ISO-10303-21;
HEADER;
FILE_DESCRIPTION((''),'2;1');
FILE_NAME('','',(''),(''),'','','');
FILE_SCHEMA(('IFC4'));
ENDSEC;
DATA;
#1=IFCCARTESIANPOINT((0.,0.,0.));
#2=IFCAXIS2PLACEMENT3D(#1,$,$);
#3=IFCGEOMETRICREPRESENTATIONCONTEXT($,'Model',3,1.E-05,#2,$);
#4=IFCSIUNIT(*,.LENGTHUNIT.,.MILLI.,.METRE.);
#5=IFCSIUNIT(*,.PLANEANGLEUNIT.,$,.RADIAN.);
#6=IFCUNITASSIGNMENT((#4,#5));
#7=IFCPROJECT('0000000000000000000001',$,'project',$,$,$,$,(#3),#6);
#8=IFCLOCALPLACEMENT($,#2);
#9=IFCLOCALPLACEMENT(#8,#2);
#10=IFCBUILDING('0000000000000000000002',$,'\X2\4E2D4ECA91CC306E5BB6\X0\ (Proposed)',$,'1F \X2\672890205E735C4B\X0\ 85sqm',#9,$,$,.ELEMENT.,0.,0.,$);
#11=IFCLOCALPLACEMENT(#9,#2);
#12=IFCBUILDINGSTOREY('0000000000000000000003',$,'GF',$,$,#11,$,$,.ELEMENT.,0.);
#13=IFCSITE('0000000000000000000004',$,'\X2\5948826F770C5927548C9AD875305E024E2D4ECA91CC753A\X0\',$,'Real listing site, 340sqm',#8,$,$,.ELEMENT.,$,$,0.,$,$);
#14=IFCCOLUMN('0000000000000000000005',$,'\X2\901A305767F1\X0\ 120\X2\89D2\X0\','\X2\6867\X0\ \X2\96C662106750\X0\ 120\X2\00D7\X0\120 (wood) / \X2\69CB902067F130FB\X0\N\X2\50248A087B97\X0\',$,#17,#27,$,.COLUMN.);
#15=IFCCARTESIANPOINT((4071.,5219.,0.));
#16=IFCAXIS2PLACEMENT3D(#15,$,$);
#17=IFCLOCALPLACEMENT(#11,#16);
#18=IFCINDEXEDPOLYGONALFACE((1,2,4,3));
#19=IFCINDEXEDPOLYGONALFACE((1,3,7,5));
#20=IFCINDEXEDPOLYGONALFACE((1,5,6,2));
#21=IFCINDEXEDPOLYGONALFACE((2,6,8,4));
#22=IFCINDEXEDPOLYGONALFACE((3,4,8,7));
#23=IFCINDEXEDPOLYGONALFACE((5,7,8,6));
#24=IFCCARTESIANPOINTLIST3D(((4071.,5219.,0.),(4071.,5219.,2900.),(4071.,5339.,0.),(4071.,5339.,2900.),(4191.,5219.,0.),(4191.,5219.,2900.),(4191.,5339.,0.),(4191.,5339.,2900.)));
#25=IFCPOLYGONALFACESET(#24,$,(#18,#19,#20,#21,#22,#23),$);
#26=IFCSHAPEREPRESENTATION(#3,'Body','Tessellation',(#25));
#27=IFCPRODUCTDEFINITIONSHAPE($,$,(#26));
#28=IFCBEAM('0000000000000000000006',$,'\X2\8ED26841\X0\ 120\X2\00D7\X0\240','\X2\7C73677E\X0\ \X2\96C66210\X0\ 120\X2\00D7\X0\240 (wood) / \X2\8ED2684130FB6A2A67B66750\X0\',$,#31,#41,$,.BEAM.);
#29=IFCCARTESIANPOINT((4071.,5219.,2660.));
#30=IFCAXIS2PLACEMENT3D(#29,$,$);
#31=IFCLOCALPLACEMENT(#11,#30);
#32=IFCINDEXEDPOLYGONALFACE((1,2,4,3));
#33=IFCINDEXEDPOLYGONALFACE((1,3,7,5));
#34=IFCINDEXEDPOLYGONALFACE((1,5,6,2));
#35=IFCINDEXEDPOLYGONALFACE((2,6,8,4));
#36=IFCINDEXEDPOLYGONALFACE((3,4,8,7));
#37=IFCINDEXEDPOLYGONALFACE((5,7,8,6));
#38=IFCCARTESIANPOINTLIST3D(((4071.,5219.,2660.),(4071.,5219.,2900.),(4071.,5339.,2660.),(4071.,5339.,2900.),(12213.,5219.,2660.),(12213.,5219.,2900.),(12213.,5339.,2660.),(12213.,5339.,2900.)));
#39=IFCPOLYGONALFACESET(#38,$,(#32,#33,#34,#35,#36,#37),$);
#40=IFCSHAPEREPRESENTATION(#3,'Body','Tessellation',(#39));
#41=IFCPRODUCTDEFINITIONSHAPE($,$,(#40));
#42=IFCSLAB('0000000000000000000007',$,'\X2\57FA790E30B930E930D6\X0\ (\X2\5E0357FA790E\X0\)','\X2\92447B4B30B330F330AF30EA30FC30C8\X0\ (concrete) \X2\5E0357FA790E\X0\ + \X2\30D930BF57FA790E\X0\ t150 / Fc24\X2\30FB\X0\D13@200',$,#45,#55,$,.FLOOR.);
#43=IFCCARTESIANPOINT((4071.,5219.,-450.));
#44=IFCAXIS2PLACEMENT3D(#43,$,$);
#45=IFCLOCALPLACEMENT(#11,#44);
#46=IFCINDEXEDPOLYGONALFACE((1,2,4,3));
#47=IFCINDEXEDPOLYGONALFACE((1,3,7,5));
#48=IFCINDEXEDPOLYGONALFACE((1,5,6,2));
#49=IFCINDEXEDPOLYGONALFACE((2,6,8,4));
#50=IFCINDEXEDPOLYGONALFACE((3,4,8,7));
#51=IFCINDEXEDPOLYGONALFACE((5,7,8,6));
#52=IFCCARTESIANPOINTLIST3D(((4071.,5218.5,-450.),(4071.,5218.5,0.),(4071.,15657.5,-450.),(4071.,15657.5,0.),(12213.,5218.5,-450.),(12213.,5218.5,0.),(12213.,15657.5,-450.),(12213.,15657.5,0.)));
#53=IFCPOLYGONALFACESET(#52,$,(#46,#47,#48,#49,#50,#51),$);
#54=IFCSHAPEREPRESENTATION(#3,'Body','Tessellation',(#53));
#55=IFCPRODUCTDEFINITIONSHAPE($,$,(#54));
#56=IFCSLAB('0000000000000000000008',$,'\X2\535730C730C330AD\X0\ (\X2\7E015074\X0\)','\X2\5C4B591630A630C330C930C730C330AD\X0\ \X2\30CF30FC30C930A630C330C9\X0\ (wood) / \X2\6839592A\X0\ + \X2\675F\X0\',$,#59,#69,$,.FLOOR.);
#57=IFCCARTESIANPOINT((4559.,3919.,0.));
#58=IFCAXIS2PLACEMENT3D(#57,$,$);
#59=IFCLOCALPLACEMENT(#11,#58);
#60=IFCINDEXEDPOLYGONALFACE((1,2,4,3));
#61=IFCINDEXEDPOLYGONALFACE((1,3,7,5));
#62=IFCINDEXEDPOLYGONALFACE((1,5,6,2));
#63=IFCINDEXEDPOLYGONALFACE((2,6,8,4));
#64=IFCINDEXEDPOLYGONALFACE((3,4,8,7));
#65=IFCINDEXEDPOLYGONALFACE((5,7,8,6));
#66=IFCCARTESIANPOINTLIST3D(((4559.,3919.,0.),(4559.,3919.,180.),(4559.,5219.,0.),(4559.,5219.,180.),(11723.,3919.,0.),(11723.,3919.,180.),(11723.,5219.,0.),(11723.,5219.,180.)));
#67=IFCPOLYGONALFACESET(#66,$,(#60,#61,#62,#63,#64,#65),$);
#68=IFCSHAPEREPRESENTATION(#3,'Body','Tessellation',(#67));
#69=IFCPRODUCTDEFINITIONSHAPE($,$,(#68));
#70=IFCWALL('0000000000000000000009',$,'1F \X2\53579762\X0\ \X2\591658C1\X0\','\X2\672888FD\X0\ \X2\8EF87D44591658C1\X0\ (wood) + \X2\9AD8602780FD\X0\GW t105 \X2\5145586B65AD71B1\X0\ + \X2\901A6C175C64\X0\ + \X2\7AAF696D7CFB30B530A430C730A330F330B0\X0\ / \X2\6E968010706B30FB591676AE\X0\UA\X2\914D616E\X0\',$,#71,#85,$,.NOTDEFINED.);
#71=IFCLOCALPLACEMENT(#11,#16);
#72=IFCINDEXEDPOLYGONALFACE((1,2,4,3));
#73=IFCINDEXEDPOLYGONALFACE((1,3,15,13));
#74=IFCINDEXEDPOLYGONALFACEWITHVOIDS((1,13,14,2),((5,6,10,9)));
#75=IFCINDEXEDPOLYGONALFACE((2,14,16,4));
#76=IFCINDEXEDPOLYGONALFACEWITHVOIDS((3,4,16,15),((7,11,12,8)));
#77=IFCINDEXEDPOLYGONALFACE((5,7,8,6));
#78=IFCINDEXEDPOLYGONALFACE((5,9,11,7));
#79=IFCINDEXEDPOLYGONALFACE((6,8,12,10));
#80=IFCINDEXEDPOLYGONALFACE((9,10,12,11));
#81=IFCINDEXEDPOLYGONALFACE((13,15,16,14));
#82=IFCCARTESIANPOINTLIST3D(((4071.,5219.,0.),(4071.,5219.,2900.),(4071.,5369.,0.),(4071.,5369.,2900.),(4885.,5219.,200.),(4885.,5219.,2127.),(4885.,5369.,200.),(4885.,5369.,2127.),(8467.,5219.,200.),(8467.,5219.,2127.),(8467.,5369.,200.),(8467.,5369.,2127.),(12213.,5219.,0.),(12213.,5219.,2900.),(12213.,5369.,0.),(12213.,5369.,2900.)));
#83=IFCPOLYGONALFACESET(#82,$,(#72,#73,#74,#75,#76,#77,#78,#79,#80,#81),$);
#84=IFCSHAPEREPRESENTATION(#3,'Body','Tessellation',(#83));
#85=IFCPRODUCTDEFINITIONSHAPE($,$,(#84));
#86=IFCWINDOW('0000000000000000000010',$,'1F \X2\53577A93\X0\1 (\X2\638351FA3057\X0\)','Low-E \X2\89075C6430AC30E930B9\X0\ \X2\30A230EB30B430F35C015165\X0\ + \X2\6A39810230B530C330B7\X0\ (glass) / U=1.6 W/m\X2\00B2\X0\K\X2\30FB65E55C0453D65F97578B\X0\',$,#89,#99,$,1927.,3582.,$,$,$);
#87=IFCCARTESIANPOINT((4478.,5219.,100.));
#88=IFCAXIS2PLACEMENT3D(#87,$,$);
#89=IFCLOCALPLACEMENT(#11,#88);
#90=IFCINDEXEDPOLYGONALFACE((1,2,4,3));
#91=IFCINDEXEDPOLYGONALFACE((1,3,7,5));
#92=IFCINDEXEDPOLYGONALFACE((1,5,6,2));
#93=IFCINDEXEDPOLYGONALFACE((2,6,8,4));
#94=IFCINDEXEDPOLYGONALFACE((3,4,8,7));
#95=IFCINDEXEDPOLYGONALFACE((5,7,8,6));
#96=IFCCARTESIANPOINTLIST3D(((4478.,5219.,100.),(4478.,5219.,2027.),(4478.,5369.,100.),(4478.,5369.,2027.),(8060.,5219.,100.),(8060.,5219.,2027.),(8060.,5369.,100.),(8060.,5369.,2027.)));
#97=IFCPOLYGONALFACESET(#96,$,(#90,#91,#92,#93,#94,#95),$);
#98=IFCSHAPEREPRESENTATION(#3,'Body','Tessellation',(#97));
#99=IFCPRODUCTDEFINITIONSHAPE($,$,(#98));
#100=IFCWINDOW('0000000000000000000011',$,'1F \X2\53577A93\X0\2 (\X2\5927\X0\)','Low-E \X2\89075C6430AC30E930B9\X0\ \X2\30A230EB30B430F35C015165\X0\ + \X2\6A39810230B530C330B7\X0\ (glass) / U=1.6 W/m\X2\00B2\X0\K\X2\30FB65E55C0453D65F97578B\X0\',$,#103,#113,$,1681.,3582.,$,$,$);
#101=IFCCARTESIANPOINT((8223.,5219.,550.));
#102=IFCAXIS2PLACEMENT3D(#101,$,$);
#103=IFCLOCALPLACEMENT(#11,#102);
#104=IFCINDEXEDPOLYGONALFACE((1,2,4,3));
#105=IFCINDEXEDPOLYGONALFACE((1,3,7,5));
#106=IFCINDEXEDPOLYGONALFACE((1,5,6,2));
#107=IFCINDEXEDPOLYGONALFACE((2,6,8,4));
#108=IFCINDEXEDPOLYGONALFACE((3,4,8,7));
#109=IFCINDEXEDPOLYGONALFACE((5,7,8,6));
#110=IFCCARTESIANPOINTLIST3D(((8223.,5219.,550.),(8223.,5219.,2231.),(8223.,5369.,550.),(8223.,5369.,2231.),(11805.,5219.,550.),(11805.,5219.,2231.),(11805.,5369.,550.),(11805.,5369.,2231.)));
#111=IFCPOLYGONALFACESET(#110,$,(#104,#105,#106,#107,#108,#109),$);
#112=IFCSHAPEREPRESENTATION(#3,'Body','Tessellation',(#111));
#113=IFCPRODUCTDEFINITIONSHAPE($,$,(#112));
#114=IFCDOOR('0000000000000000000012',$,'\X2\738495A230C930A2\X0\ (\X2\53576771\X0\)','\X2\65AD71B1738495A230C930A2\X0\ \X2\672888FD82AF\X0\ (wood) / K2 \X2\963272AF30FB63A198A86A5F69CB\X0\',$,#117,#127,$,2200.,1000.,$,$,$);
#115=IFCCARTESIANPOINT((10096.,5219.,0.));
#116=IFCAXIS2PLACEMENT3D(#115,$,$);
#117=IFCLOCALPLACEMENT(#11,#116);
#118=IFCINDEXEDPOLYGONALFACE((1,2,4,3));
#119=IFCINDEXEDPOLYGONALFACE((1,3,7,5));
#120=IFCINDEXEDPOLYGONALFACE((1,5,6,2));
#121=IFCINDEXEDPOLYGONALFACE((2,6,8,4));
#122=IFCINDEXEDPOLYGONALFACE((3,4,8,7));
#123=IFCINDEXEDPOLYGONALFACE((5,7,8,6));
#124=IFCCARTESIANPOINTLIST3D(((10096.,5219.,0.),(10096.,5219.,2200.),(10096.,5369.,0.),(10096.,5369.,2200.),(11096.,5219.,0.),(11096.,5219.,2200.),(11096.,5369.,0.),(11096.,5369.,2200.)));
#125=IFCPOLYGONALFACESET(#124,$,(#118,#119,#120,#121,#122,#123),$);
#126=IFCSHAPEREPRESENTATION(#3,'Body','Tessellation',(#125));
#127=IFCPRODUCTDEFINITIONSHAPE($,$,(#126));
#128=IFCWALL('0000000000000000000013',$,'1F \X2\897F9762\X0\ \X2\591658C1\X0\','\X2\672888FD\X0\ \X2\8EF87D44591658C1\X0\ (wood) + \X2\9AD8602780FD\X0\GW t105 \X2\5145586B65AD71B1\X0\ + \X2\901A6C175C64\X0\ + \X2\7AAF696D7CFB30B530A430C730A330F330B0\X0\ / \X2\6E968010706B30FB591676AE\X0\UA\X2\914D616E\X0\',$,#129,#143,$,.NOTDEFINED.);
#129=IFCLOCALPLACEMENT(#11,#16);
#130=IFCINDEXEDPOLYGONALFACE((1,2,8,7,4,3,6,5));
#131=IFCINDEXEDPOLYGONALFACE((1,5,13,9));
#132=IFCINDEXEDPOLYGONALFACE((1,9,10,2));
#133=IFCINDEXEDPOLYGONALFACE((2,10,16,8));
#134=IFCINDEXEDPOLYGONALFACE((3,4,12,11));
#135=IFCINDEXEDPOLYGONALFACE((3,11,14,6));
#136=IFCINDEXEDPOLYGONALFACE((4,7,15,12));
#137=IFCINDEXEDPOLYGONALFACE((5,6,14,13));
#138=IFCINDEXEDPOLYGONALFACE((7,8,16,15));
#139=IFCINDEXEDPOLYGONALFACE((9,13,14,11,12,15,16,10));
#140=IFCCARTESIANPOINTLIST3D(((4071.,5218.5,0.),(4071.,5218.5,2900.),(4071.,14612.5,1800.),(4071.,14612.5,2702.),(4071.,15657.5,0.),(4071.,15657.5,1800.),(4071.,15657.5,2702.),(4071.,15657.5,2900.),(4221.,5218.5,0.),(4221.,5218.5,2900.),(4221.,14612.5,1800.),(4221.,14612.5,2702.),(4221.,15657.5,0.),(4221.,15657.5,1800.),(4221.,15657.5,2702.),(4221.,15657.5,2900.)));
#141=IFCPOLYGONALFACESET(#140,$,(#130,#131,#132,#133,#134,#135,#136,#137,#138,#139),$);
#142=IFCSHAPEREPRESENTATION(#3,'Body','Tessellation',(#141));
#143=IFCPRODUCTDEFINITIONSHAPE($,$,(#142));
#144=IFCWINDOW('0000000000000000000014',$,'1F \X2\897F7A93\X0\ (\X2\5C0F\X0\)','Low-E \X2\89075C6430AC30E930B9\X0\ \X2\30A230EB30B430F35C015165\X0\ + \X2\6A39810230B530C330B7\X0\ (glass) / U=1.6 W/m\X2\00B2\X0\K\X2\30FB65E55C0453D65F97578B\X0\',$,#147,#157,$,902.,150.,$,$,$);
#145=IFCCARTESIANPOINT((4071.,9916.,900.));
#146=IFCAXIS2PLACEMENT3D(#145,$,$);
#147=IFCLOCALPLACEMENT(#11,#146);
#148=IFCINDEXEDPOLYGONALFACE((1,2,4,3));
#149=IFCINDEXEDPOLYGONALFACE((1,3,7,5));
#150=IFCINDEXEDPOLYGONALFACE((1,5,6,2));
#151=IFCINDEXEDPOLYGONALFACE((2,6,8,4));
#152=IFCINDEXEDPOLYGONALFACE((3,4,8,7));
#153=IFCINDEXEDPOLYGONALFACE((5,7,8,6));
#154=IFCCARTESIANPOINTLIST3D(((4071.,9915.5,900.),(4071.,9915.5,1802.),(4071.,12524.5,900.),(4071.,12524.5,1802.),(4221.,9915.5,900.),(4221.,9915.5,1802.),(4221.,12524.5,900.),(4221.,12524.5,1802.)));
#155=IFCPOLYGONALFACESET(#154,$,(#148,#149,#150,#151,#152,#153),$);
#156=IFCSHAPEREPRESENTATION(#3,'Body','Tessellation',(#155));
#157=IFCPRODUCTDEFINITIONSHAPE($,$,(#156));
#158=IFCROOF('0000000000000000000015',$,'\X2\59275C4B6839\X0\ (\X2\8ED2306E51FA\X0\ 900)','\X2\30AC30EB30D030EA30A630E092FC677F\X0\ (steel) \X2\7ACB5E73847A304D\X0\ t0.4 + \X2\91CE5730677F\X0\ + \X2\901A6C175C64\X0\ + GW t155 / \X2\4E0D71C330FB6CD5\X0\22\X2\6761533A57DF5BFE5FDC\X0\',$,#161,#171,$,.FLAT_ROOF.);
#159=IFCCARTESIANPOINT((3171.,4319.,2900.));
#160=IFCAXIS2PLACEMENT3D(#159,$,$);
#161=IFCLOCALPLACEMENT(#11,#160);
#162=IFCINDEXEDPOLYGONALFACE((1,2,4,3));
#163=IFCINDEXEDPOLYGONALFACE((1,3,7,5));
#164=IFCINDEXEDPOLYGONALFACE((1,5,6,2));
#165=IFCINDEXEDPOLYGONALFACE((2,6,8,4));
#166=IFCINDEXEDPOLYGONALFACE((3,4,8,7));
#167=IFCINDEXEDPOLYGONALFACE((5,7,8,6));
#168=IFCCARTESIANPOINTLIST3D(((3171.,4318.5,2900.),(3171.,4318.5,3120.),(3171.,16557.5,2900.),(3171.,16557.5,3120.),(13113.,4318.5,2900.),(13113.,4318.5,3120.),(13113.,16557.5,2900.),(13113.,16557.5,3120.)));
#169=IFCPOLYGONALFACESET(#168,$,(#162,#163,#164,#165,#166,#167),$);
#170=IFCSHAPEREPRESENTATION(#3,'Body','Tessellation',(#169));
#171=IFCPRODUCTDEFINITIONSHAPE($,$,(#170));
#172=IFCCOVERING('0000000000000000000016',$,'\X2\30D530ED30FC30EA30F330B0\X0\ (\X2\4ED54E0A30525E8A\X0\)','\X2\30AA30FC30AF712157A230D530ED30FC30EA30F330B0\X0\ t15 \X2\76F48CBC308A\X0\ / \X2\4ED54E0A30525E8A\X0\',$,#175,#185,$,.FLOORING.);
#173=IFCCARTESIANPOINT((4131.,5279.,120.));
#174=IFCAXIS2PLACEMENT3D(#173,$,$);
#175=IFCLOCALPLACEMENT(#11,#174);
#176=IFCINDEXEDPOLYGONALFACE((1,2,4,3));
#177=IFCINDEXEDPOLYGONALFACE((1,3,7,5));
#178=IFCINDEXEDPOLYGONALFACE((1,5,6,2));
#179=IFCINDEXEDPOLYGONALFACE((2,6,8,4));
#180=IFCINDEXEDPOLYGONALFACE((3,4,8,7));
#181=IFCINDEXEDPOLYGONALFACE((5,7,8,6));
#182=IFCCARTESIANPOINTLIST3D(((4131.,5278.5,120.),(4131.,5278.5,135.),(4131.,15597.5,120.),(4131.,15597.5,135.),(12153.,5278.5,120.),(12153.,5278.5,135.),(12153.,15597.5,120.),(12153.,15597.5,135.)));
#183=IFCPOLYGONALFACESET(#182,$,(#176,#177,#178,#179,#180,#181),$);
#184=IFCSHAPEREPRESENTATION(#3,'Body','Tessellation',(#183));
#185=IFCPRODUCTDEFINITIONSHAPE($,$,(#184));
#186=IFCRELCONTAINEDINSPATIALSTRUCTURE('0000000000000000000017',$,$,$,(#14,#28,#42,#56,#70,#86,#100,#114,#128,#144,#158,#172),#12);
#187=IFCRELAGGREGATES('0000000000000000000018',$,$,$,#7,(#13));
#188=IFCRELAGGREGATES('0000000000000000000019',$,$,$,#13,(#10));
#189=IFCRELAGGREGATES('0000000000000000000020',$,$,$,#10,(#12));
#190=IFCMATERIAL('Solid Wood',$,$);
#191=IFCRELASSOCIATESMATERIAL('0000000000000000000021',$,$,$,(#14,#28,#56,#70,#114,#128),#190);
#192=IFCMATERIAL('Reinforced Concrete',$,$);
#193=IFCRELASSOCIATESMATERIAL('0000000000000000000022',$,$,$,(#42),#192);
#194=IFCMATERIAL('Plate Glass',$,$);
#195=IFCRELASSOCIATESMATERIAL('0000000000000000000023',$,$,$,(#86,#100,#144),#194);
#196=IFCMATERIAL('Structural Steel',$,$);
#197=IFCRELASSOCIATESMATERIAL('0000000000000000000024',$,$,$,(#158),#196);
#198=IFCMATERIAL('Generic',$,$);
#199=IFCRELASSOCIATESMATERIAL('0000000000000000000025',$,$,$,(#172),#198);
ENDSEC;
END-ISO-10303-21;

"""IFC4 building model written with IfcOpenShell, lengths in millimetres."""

from ifc_helpers import new_model, si_unit, frame, frame_2d, origin, place, context, project, spatial, rectangle, extrude, material, element, fill, save


model = new_model("IFC4")

# Units and contexts
model_context = context("Model", 3, precision=1e-05, world=origin())
ifc_project = project(units=[si_unit("LENGTHUNIT", "METRE", prefix="MILLI"), si_unit("PLANEANGLEUNIT", "RADIAN")], contexts=[model_context])

# Site, building, storey
site_placement = place(None, origin())
site = spatial("IfcSite", under=ifc_project, at=site_placement, Name="奈良県大和高田市中今里町", ObjectType="Real listing site, 340sqm", CompositionType="ELEMENT", RefElevation=0.0)
building_placement = place(site_placement, origin())
building = spatial("IfcBuilding", under=site, at=building_placement, Name="中今里の家 (Proposed)", ObjectType="1F 木造平屋 85sqm", CompositionType="ELEMENT", ElevationOfRefHeight=0.0, ElevationOfTerrain=0.0)
storey_placement = place(building_placement, origin())
storey = spatial("IfcBuildingStorey", under=building, at=storey_placement, Name="GF", CompositionType="ELEMENT", Elevation=0.0)

# Column
ifc_material_1 = material(Name="Solid Wood")
column_1_placement = place(storey_placement, frame((4071.0, 5219.0, 0.0)))
element("IfcColumn", 1, at=column_1_placement, inside=storey, material=ifc_material_1, Name="通し柱 120角", Description="桧 集成材 120×120 (wood) / 構造柱・N値計算", PredefinedType="COLUMN", context=model_context, shape_type="SweptSolid", body=[
    extrude(rectangle(XDim=120.0, YDim=120.0, at=frame_2d((60.0, 60.0))), frame((4071.0, 5219.0, 0.0)), (0.0, 0.0, 1.0), 2900.0),
])

# Beam
beam_1_placement = place(storey_placement, frame((4071.0, 5219.0, 2660.0)))
element("IfcBeam", 2, at=beam_1_placement, inside=storey, material=ifc_material_1, Name="軒桁 120×240", Description="米松 集成 120×240 (wood) / 軒桁・横架材", PredefinedType="BEAM", context=model_context, shape_type="SweptSolid", body=[
    extrude(rectangle(XDim=8142.0, YDim=120.0, at=frame_2d((4071.0, 60.0))), frame((4071.0, 5219.0, 2660.0)), (0.0, 0.0, 1.0), 240.0),
])

# Slabs
ifc_material_2 = material(Name="Reinforced Concrete")
slab_1_placement = place(storey_placement, frame((4071.0, 5219.0, -450.0)))
element("IfcSlab", 3, at=slab_1_placement, inside=storey, material=ifc_material_2, Name="基礎スラブ (布基礎)", Description="鉄筋コンクリート (concrete) 布基礎 + ベタ基礎 t150 / Fc24・D13@200", PredefinedType="FLOOR", context=model_context, shape_type="SweptSolid", body=[
    extrude(rectangle(XDim=8142.0, YDim=10439.0, at=frame_2d((4071.0, 5219.0))), frame((4071.0, 5219.0, -450.0)), (0.0, 0.0, 1.0), 450.0),
])
slab_2_placement = place(storey_placement, frame((4559.0, 3919.0, 0.0)))
element("IfcSlab", 4, at=slab_2_placement, inside=storey, material=ifc_material_1, Name="南デッキ (縁側)", Description="屋外ウッドデッキ ハードウッド (wood) / 根太 + 束", PredefinedType="FLOOR", context=model_context, shape_type="SweptSolid", body=[
    extrude(rectangle(XDim=7164.0, YDim=1300.0, at=frame_2d((3582.0, 650.0))), frame((4559.0, 3919.0, 0.0)), (0.0, 0.0, 1.0), 180.0),
])

# Wall, openings, windows, door
wall_1_placement = place(storey_placement, frame((4071.0, 5219.0, 0.0)))
wall_1 = element("IfcWall", 5, at=wall_1_placement, inside=storey, material=ifc_material_1, Name="1F 南面 外壁", Description="木製 軸組外壁 (wood) + 高性能GW t105 充填断熱 + 通気層 + 窯業系サイディング / 準耐火・外皮UA配慮", PredefinedType="NOTDEFINED", context=model_context, shape_type="SweptSolid", body=[
    extrude(rectangle(XDim=8142.0, YDim=150.0, at=frame_2d((4071.0, 75.0))), frame((4071.0, 5219.0, 0.0)), (0.0, 0.0, 1.0), 2900.0),
])
opening_1_placement = place(storey_placement, frame((4478.0, 5219.0, 100.0)))
opening_1 = element("IfcOpeningElement", 6, at=opening_1_placement, cuts=wall_1, PredefinedType="NOTDEFINED", context=model_context, shape_type="SweptSolid", body=[
    extrude(rectangle(XDim=3582.0, YDim=150.0, at=frame_2d((1791.0, 75.0))), frame((4478.0, 5219.0, 100.0)), (0.0, 0.0, 1.0), 1927.0),
])
opening_2_placement = place(storey_placement, frame((8223.0, 5219.0, 550.0)))
opening_2 = element("IfcOpeningElement", 7, at=opening_2_placement, cuts=wall_1, PredefinedType="NOTDEFINED", context=model_context, shape_type="SweptSolid", body=[
    extrude(rectangle(XDim=3582.0, YDim=150.0, at=frame_2d((1791.0, 75.0))), frame((8223.0, 5219.0, 550.0)), (0.0, 0.0, 1.0), 1681.0),
])
opening_3_placement = place(storey_placement, frame((10096.0, 5219.0, 0.0)))
opening_3 = element("IfcOpeningElement", 8, at=opening_3_placement, cuts=wall_1, PredefinedType="NOTDEFINED", context=model_context, shape_type="SweptSolid", body=[
    extrude(rectangle(XDim=1000.0, YDim=150.0, at=frame_2d((500.0, 75.0))), frame((10096.0, 5219.0, 0.0)), (0.0, 0.0, 1.0), 2200.0),
])
ifc_material_3 = material(Name="Plate Glass")
window_1_placement = place(storey_placement, frame((4478.0, 5219.0, 100.0)))
window_1 = element("IfcWindow", 9, at=window_1_placement, inside=storey, material=ifc_material_3, Name="1F 南窓1 (掃出し)", Description="Low-E 複層ガラス アルゴン封入 + 樹脂サッシ (glass) / U=1.6 W/m²K・日射取得型", OverallHeight=1927.0, OverallWidth=3582.0, context=model_context, shape_type="SweptSolid", body=[
    extrude(rectangle(XDim=3582.0, YDim=150.0, at=frame_2d((1791.0, 75.0))), frame((4478.0, 5219.0, 100.0)), (0.0, 0.0, 1.0), 1927.0),
])
fill(opening_1, window_1)
window_2_placement = place(storey_placement, frame((8223.0, 5219.0, 550.0)))
window_2 = element("IfcWindow", 10, at=window_2_placement, inside=storey, material=ifc_material_3, Name="1F 南窓2 (大)", Description="Low-E 複層ガラス アルゴン封入 + 樹脂サッシ (glass) / U=1.6 W/m²K・日射取得型", OverallHeight=1681.0, OverallWidth=3582.0, context=model_context, shape_type="SweptSolid", body=[
    extrude(rectangle(XDim=3582.0, YDim=150.0, at=frame_2d((1791.0, 75.0))), frame((8223.0, 5219.0, 550.0)), (0.0, 0.0, 1.0), 1681.0),
])
fill(opening_2, window_2)
door_placement = place(storey_placement, frame((10096.0, 5219.0, 0.0)))
door = element("IfcDoor", 11, at=door_placement, inside=storey, material=ifc_material_1, Name="玄関ドア (南東)", Description="断熱玄関ドア 木製芯 (wood) / K2 防犯・採風機構", OverallHeight=2200.0, OverallWidth=1000.0, context=model_context, shape_type="SweptSolid", body=[
    extrude(rectangle(XDim=1000.0, YDim=150.0, at=frame_2d((500.0, 75.0))), frame((10096.0, 5219.0, 0.0)), (0.0, 0.0, 1.0), 2200.0),
])
fill(opening_3, door)

# Wall, opening, window
wall_2_placement = place(storey_placement, frame((4071.0, 5219.0, 0.0)))
wall_2 = element("IfcWall", 12, at=wall_2_placement, inside=storey, material=ifc_material_1, Name="1F 西面 外壁", Description="木製 軸組外壁 (wood) + 高性能GW t105 充填断熱 + 通気層 + 窯業系サイディング / 準耐火・外皮UA配慮", PredefinedType="NOTDEFINED", context=model_context, shape_type="SweptSolid", body=[
    extrude(rectangle(XDim=150.0, YDim=10439.0, at=frame_2d((75.0, 5219.0))), frame((4071.0, 5219.0, 0.0)), (0.0, 0.0, 1.0), 2900.0),
])
opening_4_placement = place(storey_placement, frame((4071.0, 9916.0, 900.0)))
opening_4 = element("IfcOpeningElement", 13, at=opening_4_placement, cuts=wall_2, PredefinedType="NOTDEFINED", context=model_context, shape_type="SweptSolid", body=[
    extrude(rectangle(XDim=150.0, YDim=2609.0, at=frame_2d((75.0, 1304.0))), frame((4071.0, 9916.0, 900.0)), (0.0, 0.0, 1.0), 902.0),
])
window_3_placement = place(storey_placement, frame((4071.0, 9916.0, 900.0)))
window_3 = element("IfcWindow", 14, at=window_3_placement, inside=storey, material=ifc_material_3, Name="1F 西窓 (小)", Description="Low-E 複層ガラス アルゴン封入 + 樹脂サッシ (glass) / U=1.6 W/m²K・日射取得型", OverallHeight=902.0, OverallWidth=150.0, context=model_context, shape_type="SweptSolid", body=[
    extrude(rectangle(XDim=150.0, YDim=2609.0, at=frame_2d((75.0, 1304.0))), frame((4071.0, 9916.0, 900.0)), (0.0, 0.0, 1.0), 902.0),
])
fill(opening_4, window_3)

# Roof
ifc_material_4 = material(Name="Structural Steel")
roof_placement = place(storey_placement, frame((3171.0, 4319.0, 2900.0)))
element("IfcRoof", 15, at=roof_placement, inside=storey, material=ifc_material_4, Name="大屋根 (軒の出 900)", Description="ガルバリウム鋼板 (steel) 立平葺き t0.4 + 野地板 + 通気層 + GW t155 / 不燃・法22条区域対応", PredefinedType="FLAT_ROOF", context=model_context, shape_type="SweptSolid", body=[
    extrude(rectangle(XDim=9942.0, YDim=12239.0, at=frame_2d((4971.0, 6119.0))), frame((3171.0, 4319.0, 2900.0)), (0.0, 0.0, 1.0), 220.0),
])

# Covering
ifc_material_5 = material(Name="Generic")
covering_1_placement = place(storey_placement, frame((4131.0, 5279.0, 120.0)))
element("IfcCovering", 16, at=covering_1_placement, inside=storey, material=ifc_material_5, Name="フローリング (仕上げ床)", Description="オーク無垢フローリング t15 直貼り / 仕上げ床", PredefinedType="FLOORING", context=model_context, shape_type="SweptSolid", body=[
    extrude(rectangle(XDim=8022.0, YDim=10319.0, at=frame_2d((4011.0, 5159.0))), frame((4131.0, 5279.0, 120.0)), (0.0, 0.0, 1.0), 15.0),
])

save(model, "model.ifc")
